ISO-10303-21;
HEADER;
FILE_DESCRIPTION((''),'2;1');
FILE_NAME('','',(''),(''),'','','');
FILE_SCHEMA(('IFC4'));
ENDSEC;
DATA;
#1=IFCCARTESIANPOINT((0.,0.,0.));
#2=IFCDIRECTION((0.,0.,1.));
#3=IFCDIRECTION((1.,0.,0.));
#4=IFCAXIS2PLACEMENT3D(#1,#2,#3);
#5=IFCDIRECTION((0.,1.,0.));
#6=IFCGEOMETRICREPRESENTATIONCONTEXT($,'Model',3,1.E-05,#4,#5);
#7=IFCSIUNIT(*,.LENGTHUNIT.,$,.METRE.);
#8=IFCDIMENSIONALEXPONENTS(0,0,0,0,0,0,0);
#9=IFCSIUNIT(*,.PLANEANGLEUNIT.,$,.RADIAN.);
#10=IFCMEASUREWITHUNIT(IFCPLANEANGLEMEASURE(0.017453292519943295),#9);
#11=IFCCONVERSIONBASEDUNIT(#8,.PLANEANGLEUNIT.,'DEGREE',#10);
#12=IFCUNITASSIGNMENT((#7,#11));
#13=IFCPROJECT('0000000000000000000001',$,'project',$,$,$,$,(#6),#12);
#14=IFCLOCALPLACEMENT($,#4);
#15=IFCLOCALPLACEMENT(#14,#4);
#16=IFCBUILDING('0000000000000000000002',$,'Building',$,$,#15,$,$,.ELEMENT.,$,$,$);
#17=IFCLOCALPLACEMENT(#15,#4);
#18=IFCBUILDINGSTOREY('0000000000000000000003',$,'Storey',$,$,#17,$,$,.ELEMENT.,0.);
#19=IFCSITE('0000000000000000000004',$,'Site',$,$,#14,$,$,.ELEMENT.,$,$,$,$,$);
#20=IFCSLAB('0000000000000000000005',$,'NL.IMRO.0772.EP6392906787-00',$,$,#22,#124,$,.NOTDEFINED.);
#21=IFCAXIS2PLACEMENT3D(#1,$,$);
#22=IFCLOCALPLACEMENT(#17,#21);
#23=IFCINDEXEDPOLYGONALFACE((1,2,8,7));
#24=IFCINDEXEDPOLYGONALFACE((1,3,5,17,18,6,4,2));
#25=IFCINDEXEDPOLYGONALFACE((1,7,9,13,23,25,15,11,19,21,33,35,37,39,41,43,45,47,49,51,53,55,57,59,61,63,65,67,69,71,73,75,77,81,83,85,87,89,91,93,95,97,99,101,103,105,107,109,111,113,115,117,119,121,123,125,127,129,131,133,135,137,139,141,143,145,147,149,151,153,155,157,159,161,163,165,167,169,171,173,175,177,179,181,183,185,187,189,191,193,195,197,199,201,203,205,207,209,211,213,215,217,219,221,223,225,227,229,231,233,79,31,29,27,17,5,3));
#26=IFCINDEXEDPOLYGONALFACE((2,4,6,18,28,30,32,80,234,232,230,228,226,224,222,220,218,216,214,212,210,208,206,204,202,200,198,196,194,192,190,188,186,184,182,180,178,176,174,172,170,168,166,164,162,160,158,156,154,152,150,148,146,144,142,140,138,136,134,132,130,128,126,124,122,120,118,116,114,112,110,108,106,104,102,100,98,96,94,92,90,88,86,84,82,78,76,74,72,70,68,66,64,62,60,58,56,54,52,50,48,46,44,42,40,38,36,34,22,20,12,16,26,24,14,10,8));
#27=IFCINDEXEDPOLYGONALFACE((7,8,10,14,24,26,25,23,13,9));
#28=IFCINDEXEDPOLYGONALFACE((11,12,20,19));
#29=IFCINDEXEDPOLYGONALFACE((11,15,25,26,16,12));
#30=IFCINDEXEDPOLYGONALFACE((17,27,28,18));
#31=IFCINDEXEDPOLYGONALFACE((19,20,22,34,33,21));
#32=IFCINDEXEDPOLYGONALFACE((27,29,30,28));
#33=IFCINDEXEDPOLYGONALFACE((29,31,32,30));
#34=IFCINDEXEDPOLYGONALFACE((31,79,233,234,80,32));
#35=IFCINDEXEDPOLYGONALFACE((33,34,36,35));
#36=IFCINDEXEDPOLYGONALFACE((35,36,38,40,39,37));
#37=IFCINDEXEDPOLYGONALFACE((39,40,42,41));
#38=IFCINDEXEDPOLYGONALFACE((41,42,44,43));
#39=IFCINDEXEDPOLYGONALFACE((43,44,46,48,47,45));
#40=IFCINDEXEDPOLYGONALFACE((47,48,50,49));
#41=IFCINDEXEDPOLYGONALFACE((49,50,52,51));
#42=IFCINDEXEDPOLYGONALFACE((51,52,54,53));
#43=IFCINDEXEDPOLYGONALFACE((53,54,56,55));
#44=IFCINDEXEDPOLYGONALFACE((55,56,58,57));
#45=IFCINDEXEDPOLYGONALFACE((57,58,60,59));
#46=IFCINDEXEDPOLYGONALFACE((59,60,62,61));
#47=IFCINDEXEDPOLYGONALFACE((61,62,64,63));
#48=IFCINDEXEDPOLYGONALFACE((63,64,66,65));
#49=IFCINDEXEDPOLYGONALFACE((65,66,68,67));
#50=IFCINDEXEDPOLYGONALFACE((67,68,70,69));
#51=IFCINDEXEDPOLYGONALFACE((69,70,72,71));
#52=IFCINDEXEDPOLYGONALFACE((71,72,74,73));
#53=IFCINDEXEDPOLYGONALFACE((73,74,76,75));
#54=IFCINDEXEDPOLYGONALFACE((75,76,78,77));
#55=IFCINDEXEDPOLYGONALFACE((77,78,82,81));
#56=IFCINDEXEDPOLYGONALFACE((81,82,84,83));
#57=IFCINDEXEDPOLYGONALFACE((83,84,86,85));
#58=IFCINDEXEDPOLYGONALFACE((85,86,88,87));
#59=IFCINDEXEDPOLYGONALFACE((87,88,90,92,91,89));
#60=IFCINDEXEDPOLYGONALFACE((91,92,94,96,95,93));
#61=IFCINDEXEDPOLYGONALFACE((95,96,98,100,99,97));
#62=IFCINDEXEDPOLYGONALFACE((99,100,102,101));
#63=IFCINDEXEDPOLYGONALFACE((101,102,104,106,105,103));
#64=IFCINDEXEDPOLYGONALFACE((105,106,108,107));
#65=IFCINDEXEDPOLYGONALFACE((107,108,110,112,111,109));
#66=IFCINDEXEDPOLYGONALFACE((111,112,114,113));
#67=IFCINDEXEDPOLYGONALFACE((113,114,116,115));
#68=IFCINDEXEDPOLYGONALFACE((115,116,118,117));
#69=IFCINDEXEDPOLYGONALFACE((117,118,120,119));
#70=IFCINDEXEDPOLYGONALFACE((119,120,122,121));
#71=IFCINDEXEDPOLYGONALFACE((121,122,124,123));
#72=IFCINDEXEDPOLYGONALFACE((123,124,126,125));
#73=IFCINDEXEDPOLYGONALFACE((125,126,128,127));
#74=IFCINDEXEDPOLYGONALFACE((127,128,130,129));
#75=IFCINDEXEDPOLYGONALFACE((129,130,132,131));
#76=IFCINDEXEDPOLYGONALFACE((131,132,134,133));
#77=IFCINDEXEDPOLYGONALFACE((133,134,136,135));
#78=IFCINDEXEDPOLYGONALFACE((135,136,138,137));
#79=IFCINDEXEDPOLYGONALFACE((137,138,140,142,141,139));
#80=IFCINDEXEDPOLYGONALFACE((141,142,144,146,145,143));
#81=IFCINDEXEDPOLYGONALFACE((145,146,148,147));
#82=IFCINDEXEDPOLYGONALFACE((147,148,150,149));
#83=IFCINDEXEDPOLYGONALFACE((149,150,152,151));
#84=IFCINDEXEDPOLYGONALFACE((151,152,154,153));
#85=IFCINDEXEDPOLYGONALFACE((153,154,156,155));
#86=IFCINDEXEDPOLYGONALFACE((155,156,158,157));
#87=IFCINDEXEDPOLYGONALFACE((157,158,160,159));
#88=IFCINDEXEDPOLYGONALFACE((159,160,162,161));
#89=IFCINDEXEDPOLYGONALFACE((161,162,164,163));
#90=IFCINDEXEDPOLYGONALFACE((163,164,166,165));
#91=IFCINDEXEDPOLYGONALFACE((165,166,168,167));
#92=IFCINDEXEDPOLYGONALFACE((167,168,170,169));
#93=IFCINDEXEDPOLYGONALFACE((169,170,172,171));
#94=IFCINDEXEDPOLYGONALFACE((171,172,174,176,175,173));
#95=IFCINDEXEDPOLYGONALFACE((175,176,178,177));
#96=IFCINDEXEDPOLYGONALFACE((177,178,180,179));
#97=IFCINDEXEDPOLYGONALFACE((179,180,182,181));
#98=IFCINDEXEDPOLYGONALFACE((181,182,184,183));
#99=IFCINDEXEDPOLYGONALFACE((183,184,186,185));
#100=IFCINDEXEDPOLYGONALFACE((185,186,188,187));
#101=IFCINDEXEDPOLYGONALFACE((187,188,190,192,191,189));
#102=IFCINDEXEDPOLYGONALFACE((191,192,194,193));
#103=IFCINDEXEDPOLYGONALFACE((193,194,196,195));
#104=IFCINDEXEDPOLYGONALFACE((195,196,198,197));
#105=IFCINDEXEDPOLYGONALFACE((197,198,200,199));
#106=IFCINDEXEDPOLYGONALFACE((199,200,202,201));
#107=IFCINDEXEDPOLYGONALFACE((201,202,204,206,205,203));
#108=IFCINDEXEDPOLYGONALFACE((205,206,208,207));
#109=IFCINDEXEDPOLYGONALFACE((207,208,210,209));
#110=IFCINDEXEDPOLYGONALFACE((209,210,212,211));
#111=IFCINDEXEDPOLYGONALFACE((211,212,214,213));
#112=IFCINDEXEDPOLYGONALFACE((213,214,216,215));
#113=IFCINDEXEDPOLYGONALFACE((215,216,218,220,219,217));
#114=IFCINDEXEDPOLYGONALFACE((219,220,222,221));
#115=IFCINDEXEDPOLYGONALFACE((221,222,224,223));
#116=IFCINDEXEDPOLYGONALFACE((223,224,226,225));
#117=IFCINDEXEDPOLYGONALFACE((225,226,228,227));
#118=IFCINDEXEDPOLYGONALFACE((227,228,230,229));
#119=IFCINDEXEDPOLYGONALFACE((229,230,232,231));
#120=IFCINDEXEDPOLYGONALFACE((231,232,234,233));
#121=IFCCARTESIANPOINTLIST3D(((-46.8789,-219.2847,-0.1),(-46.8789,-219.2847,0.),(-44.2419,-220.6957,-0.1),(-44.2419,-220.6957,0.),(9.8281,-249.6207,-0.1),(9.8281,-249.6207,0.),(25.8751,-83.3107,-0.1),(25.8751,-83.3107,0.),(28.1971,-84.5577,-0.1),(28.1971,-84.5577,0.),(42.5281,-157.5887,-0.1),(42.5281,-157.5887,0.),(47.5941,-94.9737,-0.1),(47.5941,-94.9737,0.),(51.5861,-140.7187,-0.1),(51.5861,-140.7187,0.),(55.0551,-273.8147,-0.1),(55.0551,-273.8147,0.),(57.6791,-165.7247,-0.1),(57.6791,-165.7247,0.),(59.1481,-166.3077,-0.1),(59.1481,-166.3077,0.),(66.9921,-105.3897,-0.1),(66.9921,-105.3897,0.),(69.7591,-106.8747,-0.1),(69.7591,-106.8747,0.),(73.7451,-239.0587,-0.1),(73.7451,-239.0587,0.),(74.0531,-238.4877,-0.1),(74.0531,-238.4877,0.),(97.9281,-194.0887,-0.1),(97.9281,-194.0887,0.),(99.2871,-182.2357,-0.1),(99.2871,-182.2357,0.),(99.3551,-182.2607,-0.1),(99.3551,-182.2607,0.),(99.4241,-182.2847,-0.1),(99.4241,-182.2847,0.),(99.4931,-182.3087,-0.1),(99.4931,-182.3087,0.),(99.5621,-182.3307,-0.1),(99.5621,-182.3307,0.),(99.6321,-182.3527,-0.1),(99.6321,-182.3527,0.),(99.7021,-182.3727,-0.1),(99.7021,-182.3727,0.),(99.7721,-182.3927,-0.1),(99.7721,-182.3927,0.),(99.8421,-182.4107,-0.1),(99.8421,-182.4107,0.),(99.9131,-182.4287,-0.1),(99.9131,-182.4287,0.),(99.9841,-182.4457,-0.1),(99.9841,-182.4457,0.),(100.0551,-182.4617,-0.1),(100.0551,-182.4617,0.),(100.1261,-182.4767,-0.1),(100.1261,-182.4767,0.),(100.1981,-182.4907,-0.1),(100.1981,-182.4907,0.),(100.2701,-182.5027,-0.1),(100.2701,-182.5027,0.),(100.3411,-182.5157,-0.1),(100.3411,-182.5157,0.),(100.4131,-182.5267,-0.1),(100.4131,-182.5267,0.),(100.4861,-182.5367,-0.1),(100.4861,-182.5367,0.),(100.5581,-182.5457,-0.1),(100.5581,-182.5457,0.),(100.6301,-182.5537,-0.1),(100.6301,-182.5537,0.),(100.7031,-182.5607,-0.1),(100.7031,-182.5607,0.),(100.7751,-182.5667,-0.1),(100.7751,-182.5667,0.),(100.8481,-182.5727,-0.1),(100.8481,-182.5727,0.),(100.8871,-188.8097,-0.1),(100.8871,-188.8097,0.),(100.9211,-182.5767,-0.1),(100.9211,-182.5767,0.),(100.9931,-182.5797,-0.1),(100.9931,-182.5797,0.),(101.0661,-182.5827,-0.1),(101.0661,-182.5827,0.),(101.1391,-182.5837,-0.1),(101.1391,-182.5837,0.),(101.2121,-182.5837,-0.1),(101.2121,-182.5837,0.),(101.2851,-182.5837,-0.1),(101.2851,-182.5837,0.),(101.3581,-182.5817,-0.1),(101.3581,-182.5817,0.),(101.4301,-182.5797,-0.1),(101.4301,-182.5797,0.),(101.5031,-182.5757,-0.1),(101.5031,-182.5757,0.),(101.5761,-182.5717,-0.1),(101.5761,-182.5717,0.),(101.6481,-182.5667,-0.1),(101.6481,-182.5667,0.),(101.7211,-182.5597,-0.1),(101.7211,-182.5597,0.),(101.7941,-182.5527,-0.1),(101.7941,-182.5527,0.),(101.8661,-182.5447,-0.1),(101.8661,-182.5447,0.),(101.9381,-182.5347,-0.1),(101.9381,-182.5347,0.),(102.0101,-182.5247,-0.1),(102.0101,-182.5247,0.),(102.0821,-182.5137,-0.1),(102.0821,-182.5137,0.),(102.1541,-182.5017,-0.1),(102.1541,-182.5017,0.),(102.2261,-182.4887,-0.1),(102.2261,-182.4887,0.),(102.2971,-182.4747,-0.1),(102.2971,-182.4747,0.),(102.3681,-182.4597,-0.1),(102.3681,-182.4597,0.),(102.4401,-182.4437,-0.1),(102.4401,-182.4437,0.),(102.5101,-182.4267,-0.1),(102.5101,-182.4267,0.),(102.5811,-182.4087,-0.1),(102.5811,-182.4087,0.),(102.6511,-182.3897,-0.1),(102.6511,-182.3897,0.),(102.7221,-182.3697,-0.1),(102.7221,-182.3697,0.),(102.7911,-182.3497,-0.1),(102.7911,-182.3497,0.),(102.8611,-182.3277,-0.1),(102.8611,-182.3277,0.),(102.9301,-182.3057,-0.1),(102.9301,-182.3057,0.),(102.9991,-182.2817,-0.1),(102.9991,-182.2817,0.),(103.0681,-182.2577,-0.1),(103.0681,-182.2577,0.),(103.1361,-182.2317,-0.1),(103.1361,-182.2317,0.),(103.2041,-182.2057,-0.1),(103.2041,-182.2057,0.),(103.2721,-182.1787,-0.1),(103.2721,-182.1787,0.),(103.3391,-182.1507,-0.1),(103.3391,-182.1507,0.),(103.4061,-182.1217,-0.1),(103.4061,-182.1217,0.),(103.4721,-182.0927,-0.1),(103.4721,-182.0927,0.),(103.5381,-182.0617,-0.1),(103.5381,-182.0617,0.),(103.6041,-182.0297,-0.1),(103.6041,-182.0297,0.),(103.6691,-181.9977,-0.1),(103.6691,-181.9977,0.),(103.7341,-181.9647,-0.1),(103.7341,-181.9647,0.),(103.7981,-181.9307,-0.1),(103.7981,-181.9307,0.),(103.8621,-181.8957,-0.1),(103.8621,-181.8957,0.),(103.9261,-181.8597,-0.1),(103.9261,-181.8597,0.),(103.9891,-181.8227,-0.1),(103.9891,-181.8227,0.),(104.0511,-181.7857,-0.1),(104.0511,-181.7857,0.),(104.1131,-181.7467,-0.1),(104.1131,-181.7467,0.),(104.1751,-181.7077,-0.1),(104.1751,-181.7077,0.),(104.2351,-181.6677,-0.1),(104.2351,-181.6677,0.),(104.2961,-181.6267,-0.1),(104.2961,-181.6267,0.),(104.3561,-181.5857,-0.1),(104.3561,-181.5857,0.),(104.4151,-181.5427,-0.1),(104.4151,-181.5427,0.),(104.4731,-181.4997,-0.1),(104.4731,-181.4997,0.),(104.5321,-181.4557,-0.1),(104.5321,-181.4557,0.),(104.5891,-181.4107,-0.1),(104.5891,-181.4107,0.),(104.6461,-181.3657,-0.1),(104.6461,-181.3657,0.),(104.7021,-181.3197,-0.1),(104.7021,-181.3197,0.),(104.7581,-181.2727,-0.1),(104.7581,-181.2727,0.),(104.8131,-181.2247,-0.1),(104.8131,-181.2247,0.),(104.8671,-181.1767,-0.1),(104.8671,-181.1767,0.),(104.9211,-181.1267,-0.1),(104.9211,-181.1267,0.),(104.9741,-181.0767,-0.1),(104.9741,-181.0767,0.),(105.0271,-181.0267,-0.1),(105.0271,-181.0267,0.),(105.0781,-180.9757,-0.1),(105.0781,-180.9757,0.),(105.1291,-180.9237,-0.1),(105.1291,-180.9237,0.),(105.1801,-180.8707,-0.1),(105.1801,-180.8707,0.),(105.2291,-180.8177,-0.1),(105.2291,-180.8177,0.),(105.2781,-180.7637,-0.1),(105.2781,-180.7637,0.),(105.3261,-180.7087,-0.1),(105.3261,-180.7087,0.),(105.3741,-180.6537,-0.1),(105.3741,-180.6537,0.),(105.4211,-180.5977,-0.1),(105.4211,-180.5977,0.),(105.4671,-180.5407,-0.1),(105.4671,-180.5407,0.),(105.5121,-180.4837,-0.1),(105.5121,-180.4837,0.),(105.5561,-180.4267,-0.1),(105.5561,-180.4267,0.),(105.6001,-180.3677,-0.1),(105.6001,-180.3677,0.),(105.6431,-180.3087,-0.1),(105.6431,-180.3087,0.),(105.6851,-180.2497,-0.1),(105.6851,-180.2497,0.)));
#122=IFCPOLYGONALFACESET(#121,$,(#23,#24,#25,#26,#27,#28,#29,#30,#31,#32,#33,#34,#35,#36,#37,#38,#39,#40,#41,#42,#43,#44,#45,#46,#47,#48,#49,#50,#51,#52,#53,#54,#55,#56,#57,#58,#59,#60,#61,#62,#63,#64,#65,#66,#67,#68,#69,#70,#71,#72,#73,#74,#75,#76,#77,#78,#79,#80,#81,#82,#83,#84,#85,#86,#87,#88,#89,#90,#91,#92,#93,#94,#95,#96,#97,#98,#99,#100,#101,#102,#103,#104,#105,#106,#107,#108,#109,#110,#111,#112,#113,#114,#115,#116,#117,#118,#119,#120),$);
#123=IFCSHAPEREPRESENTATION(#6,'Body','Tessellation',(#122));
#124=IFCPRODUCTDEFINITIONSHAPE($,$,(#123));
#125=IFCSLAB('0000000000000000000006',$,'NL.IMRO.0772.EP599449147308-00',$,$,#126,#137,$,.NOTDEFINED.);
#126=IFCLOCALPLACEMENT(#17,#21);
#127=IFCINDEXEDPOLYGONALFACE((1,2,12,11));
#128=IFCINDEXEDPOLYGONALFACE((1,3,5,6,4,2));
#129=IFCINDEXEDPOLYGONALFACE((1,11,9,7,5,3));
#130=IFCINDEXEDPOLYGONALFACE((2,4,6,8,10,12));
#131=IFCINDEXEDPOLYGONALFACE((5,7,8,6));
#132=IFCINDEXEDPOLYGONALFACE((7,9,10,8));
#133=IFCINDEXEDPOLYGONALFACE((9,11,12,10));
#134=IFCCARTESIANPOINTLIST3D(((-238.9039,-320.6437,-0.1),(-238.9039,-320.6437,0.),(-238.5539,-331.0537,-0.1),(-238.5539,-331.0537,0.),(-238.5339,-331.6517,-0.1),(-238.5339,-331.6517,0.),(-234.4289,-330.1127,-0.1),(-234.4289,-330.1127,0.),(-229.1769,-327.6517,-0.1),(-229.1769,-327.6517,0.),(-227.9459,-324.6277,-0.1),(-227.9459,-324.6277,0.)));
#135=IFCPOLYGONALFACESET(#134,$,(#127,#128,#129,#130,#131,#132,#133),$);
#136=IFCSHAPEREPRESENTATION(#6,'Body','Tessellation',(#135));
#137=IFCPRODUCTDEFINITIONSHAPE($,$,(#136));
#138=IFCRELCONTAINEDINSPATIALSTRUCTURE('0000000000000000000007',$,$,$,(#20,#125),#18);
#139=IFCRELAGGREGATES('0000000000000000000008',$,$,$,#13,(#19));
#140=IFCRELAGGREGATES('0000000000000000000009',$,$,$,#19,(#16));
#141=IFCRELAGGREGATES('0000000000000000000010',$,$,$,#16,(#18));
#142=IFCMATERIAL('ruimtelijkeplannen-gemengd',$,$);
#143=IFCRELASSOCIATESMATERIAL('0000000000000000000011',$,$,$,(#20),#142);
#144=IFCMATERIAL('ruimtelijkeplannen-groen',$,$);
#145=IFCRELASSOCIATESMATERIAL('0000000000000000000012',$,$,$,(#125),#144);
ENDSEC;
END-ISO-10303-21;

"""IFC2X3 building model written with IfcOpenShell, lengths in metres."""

from ifc_helpers import new_model, entity, si_unit, converted_unit, direction, frame, origin_with_axes, place, context, project, spatial, polyline, outline, extrude, material, element, save


model = new_model("IFC2X3")

# Units and contexts
model_context = context("Model", 3, precision=1e-05, world=origin_with_axes(), true_north=direction((0.0, 1.0, 0.0)))
ifc_project = project(units=[si_unit("LENGTHUNIT", "METRE"), converted_unit("PLANEANGLEUNIT", "DEGREE", entity("IfcPlaneAngleMeasure", 0.017453292519943295), si_unit("PLANEANGLEUNIT", "RADIAN"), dimensions=[0, 0, 0, 0, 0, 0, 0])], contexts=[model_context])

# Site, building, storey
site_placement = place(None, origin_with_axes())
site = spatial("IfcSite", under=ifc_project, at=site_placement, Name="Site", CompositionType="ELEMENT")
building_placement = place(site_placement, origin_with_axes())
building = spatial("IfcBuilding", under=site, at=building_placement, Name="Building", CompositionType="ELEMENT")
storey_placement = place(building_placement, origin_with_axes())
storey = spatial("IfcBuildingStorey", under=building, at=storey_placement, Name="Storey", CompositionType="ELEMENT", Elevation=0.0)

# Slabs
ifc_material_1 = material(Name="ruimtelijkeplannen-groen")
ifc_material_2 = material(Name="ruimtelijkeplannen-gemengd")
slab_1_placement = place(storey_placement, frame((0.0, 0.0, -0.1), z_axis=(0.0, 0.0, 1.0), x_axis=(1.0, 0.0, 0.0)))
element("IfcSlab", 1, at=slab_1_placement, inside=storey, material=ifc_material_2, Name="NL.IMRO.0772.EP6392906787-00", PredefinedType="NOTDEFINED", context=model_context, shape_type="SweptSolid", body=[
    extrude(outline(polyline([(99.3551, -182.2607), (99.4241, -182.2847), (99.4931, -182.3087), (99.5621, -182.3307), (99.6321, -182.3527), (99.7021, -182.3727), (99.7721, -182.3927), (99.8421, -182.4107), (99.9131, -182.4287), (99.9841, -182.4457), (100.0551, -182.4617), (100.1261, -182.4767), (100.1981, -182.4907), (100.2701, -182.5027), (100.3411, -182.5157), (100.4131, -182.5267), (100.4861, -182.5367), (100.5581, -182.5457), (100.6301, -182.5537), (100.7031, -182.5607), (100.7751, -182.5667), (100.8481, -182.5727), (100.9211, -182.5767), (100.9931, -182.5797), (101.0661, -182.5827), (101.1391, -182.5837), (101.2121, -182.5837), (101.2851, -182.5837), (101.3581, -182.5817), (101.4301, -182.5797), (101.5031, -182.5757), (101.5761, -182.5717), (101.6481, -182.5667), (101.7211, -182.5597), (101.7941, -182.5527), (101.8661, -182.5447), (101.9381, -182.5347), (102.0101, -182.5247), (102.0821, -182.5137), (102.1541, -182.5017), (102.2261, -182.4887), (102.2971, -182.4747), (102.3681, -182.4597), (102.4401, -182.4437), (102.5101, -182.4267), (102.5811, -182.4087), (102.6511, -182.3897), (102.7221, -182.3697), (102.7911, -182.3497), (102.8611, -182.3277), (102.9301, -182.3057), (102.9991, -182.2817), (103.0681, -182.2577), (103.1361, -182.2317), (103.2041, -182.2057), (103.2721, -182.1787), (103.3391, -182.1507), (103.4061, -182.1217), (103.4721, -182.0927), (103.5381, -182.0617), (103.6041, -182.0297), (103.6691, -181.9977), (103.7341, -181.9647), (103.7981, -181.9307), (103.8621, -181.8957), (103.9261, -181.8597), (103.9891, -181.8227), (104.0511, -181.7857), (104.1131, -181.7467), (104.1751, -181.7077), (104.2351, -181.6677), (104.2961, -181.6267), (104.3561, -181.5857), (104.4151, -181.5427), (104.4731, -181.4997), (104.5321, -181.4557), (104.5891, -181.4107), (104.6461, -181.3657), (104.7021, -181.3197), (104.7581, -181.2727), (104.8131, -181.2247), (104.8671, -181.1767), (104.9211, -181.1267), (104.9741, -181.0767), (105.0271, -181.0267), (105.0781, -180.9757), (105.1291, -180.9237), (105.1801, -180.8707), (105.2291, -180.8177), (105.2781, -180.7637), (105.3261, -180.7087), (105.3741, -180.6537), (105.4211, -180.5977), (105.4671, -180.5407), (105.5121, -180.4837), (105.5561, -180.4267), (105.6001, -180.3677), (105.6431, -180.3087), (105.6851, -180.2497), (100.8871, -188.8097), (97.9281, -194.0887), (74.0531, -238.4877), (73.7451, -239.0587), (55.0551, -273.8147), (9.8281, -249.6207), (-44.2419, -220.6957), (-46.8789, -219.2847), (25.8751, -83.3107), (28.1971, -84.5577), (47.5941, -94.9737), (66.9921, -105.3897), (69.7591, -106.8747), (51.5861, -140.7187), (42.5281, -157.5887), (57.6791, -165.7247), (59.1481, -166.3077), (99.2871, -182.2357), (99.3551, -182.2607)])), origin_with_axes(), (0.0, 0.0, 1.0), 0.1),
])
slab_2_placement = place(storey_placement, frame((0.0, 0.0, -0.1), z_axis=(0.0, 0.0, 1.0), x_axis=(1.0, 0.0, 0.0)))
element("IfcSlab", 2, at=slab_2_placement, inside=storey, material=ifc_material_1, Name="NL.IMRO.0772.EP599449147308-00", PredefinedType="NOTDEFINED", context=model_context, shape_type="SweptSolid", body=[
    extrude(outline(polyline([(-238.5339, -331.6517), (-238.5539, -331.0537), (-238.9039, -320.6437), (-227.9459, -324.6277), (-229.1769, -327.6517), (-234.4289, -330.1127), (-238.5339, -331.6517)])), origin_with_axes(), (0.0, 0.0, 1.0), 0.1),
])

save(model, "model.ifc")
